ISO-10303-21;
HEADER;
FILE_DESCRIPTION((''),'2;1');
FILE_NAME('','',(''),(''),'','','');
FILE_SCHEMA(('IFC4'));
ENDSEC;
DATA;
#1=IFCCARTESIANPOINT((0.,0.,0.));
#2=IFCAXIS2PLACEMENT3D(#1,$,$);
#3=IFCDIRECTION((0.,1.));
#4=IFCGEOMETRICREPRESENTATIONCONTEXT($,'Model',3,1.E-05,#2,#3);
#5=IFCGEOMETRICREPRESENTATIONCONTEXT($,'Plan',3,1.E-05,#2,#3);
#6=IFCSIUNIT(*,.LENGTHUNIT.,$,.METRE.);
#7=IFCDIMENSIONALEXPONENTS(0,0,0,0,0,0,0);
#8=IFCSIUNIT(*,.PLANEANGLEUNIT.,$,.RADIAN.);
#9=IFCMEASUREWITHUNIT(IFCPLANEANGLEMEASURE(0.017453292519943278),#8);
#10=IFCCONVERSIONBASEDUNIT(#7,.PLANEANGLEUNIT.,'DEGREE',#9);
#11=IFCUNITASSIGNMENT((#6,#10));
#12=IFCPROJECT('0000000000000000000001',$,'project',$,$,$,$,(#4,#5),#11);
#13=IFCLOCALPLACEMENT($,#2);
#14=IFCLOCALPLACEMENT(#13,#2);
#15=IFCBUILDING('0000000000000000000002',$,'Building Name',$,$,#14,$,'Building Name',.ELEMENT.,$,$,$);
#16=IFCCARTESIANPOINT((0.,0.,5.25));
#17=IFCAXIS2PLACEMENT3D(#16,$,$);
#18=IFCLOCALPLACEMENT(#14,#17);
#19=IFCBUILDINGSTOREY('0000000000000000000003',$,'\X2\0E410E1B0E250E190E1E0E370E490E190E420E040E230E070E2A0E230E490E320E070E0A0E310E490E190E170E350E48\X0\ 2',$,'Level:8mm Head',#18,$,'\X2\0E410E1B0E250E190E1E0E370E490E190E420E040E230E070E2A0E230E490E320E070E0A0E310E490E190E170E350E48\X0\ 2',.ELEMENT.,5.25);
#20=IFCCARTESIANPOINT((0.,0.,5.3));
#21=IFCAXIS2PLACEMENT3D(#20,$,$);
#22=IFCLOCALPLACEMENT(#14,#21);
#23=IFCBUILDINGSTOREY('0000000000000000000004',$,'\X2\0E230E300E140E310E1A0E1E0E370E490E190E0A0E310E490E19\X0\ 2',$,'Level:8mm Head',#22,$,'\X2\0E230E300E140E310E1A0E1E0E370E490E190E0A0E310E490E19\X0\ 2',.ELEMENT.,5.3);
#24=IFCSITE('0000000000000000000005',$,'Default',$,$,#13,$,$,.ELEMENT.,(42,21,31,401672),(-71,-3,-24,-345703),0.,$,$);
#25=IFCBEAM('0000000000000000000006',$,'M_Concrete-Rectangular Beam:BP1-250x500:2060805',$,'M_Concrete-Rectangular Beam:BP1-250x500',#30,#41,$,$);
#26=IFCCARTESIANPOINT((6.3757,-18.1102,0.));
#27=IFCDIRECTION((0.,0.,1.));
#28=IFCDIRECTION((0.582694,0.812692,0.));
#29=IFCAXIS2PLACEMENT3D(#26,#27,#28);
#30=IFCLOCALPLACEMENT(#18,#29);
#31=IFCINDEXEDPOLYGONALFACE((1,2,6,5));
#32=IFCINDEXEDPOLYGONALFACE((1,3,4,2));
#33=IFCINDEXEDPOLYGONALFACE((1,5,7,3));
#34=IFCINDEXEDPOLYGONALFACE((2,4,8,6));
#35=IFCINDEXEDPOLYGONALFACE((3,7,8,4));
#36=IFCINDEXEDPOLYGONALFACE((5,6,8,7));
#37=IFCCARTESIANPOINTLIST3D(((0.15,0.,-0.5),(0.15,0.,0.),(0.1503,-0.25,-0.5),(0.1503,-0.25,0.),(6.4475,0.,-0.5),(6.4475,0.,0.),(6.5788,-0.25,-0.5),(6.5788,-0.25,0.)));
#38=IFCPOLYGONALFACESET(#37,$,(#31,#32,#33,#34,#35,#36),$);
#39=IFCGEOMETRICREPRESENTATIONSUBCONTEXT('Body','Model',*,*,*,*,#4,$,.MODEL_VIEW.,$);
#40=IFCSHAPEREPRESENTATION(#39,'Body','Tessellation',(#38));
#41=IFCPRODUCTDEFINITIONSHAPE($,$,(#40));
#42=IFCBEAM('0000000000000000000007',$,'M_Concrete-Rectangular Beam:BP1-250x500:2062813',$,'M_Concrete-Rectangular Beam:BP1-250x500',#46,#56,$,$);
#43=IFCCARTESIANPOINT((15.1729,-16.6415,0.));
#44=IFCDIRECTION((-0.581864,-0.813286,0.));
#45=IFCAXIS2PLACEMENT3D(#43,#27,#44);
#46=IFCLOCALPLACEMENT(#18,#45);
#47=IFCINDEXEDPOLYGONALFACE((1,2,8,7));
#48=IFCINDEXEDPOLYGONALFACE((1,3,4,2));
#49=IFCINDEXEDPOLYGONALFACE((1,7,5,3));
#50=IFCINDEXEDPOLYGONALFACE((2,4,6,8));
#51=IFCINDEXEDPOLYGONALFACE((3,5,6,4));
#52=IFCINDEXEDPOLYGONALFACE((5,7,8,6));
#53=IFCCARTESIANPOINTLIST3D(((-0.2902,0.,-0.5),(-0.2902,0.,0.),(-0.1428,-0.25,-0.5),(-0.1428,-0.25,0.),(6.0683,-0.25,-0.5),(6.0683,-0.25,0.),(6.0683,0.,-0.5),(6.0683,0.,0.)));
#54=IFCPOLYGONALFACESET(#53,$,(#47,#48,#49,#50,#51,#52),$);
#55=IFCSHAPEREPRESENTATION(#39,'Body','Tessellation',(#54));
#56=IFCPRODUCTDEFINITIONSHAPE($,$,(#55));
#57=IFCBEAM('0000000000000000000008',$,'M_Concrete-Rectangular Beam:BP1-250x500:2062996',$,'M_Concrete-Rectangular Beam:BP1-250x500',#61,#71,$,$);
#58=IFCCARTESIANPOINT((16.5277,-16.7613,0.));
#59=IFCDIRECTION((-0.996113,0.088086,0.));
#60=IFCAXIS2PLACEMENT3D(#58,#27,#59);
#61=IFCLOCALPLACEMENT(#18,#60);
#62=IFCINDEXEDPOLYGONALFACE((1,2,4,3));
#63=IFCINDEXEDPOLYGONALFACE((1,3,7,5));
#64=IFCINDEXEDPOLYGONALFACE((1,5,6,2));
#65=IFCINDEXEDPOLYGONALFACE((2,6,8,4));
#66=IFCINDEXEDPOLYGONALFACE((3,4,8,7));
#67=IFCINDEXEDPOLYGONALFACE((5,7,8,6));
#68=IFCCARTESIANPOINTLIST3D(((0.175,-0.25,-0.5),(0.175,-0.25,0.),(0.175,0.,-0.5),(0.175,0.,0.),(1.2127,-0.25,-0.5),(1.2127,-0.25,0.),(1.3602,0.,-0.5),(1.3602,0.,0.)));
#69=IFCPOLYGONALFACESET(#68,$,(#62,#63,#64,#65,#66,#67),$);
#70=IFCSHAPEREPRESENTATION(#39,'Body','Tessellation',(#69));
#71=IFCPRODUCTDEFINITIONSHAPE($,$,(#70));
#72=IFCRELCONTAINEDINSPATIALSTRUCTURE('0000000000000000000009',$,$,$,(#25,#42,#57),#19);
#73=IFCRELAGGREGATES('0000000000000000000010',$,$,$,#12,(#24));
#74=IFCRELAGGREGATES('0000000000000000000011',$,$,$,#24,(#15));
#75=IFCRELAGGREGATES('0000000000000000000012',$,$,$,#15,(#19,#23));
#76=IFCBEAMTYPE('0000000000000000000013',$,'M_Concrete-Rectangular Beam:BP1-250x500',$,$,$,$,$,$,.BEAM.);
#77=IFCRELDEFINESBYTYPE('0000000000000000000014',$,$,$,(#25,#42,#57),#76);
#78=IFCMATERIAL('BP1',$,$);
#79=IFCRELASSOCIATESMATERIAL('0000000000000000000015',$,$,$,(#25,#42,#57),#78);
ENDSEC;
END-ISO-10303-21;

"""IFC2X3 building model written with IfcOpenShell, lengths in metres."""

from ifc_helpers import new_model, entity, si_unit, converted_unit, direction, frame, frame_2d, origin, place, context, subcontext, project, spatial, rectangle, extrude, clip, halfspace, material, type_object, element, save


model = new_model("IFC2X3")

# Units and contexts
model_context = context("Model", 3, precision=1e-05, world=origin(), true_north=direction((0.0, 1.0)))
plan_context = context("Plan", 3, precision=1e-05, world=origin(), true_north=direction((0.0, 1.0)))
body_context = subcontext(model_context, "Body", "Model", "MODEL_VIEW")
ifc_project = project(units=[si_unit("LENGTHUNIT", "METRE"), converted_unit("PLANEANGLEUNIT", "DEGREE", entity("IfcPlaneAngleMeasure", 0.017453292519943278), si_unit("PLANEANGLEUNIT", "RADIAN"), dimensions=[0, 0, 0, 0, 0, 0, 0])], contexts=[model_context, plan_context])

# Site, building, storey
site_placement = place(None, origin())
site = spatial("IfcSite", under=ifc_project, at=site_placement, Name="Default", CompositionType="ELEMENT", RefLatitude=(42, 21, 31, 401672), RefLongitude=(-71, -3, -24, -345703), RefElevation=0.0)
building_placement = place(site_placement, origin())
building = spatial("IfcBuilding", under=site, at=building_placement, Name="Building Name", LongName="Building Name", CompositionType="ELEMENT")
storey_1_placement = place(building_placement, frame((0.0, 0.0, 5.25)))
storey_1 = spatial("IfcBuildingStorey", under=building, at=storey_1_placement, Name="แปลนพื้นโครงสร้างชั้นที่ 2", ObjectType="Level:8mm Head", LongName="แปลนพื้นโครงสร้างชั้นที่ 2", CompositionType="ELEMENT", Elevation=5.25)

# Beams
ifc_material_1 = material(Name="BP1")
beam_type_1 = type_object("IfcBeamType", Name="M_Concrete-Rectangular Beam:BP1-250x500", PredefinedType="BEAM")
beam_1_placement = place(storey_1_placement, frame((6.3757, -18.1102, 0.0), z_axis=(0.0, 0.0, 1.0), x_axis=(0.582694, 0.812692, 0.0)))
element("IfcBeam", 1, at=beam_1_placement, inside=storey_1, type_object=beam_type_1, material=ifc_material_1, Name="M_Concrete-Rectangular Beam:BP1-250x500:2060805", ObjectType="M_Concrete-Rectangular Beam:BP1-250x500", context=body_context, shape_type="Clipping", body=[
    clip(clip(extrude(rectangle(XDim=0.5, YDim=0.25, at=frame_2d((0.0, 0.0), x_axis=(1.0, 0.0))), frame((0.15, -0.125, -0.25), z_axis=(1.0, 0.0, 0.0), x_axis=(0.0, 0.0, -1.0)), (0.0, 0.0, 1.0), 6.4288), halfspace(frame((0.1503, -0.2998, 0.0), z_axis=(-0.999999, -0.001021, 0.0), x_axis=(0.0, 0.0, -1.0)), False)), halfspace(frame((6.4475, 0.0, 0.0), z_axis=(0.885255, 0.465107, 0.0), x_axis=(0.0, 0.0, -1.0)), False)),
])
beam_2_placement = place(storey_1_placement, frame((15.1729, -16.6415, 0.0), z_axis=(0.0, 0.0, 1.0), x_axis=(-0.581864, -0.813286, 0.0)))
element("IfcBeam", 2, at=beam_2_placement, inside=storey_1, type_object=beam_type_1, material=ifc_material_1, Name="M_Concrete-Rectangular Beam:BP1-250x500:2062813", ObjectType="M_Concrete-Rectangular Beam:BP1-250x500", context=body_context, shape_type="Clipping", body=[
    clip(extrude(rectangle(XDim=0.5, YDim=0.25, at=frame_2d((0.0, 0.0), x_axis=(1.0, 0.0))), frame((-0.2902, -0.125, -0.25), z_axis=(1.0, 0.0, 0.0), x_axis=(0.0, 0.0, -1.0)), (0.0, 0.0, 1.0), 6.3586), halfspace(frame((-0.3013, 0.0188, -0.5), z_axis=(-0.861378, -0.507964, 0.0), x_axis=(0.507964, -0.861378, 0.0)), False)),
])
beam_3_placement = place(storey_1_placement, frame((16.5277, -16.7613, 0.0), z_axis=(0.0, 0.0, 1.0), x_axis=(-0.996113, 0.088086, 0.0)))
element("IfcBeam", 3, at=beam_3_placement, inside=storey_1, type_object=beam_type_1, material=ifc_material_1, Name="M_Concrete-Rectangular Beam:BP1-250x500:2062996", ObjectType="M_Concrete-Rectangular Beam:BP1-250x500", context=body_context, shape_type="Clipping", body=[
    clip(extrude(rectangle(XDim=0.5, YDim=0.25, at=frame_2d((0.0, 0.0), x_axis=(1.0, 0.0))), frame((0.175, -0.125, -0.25), z_axis=(1.0, 0.0, 0.0), x_axis=(0.0, 0.0, -1.0)), (0.0, 0.0, 1.0), 1.1852), halfspace(frame((4.4427, 5.2271, -0.5), z_axis=(0.861378, -0.507964, 0.0), x_axis=(-0.507964, -0.861378, 0.0)), False)),
])

# Shared definitions
storey_2_placement = place(building_placement, frame((0.0, 0.0, 5.3)))
storey_2 = spatial("IfcBuildingStorey", under=building, at=storey_2_placement, Name="ระดับพื้นชั้น 2", ObjectType="Level:8mm Head", LongName="ระดับพื้นชั้น 2", CompositionType="ELEMENT", Elevation=5.3)

save(model, "model.ifc")
